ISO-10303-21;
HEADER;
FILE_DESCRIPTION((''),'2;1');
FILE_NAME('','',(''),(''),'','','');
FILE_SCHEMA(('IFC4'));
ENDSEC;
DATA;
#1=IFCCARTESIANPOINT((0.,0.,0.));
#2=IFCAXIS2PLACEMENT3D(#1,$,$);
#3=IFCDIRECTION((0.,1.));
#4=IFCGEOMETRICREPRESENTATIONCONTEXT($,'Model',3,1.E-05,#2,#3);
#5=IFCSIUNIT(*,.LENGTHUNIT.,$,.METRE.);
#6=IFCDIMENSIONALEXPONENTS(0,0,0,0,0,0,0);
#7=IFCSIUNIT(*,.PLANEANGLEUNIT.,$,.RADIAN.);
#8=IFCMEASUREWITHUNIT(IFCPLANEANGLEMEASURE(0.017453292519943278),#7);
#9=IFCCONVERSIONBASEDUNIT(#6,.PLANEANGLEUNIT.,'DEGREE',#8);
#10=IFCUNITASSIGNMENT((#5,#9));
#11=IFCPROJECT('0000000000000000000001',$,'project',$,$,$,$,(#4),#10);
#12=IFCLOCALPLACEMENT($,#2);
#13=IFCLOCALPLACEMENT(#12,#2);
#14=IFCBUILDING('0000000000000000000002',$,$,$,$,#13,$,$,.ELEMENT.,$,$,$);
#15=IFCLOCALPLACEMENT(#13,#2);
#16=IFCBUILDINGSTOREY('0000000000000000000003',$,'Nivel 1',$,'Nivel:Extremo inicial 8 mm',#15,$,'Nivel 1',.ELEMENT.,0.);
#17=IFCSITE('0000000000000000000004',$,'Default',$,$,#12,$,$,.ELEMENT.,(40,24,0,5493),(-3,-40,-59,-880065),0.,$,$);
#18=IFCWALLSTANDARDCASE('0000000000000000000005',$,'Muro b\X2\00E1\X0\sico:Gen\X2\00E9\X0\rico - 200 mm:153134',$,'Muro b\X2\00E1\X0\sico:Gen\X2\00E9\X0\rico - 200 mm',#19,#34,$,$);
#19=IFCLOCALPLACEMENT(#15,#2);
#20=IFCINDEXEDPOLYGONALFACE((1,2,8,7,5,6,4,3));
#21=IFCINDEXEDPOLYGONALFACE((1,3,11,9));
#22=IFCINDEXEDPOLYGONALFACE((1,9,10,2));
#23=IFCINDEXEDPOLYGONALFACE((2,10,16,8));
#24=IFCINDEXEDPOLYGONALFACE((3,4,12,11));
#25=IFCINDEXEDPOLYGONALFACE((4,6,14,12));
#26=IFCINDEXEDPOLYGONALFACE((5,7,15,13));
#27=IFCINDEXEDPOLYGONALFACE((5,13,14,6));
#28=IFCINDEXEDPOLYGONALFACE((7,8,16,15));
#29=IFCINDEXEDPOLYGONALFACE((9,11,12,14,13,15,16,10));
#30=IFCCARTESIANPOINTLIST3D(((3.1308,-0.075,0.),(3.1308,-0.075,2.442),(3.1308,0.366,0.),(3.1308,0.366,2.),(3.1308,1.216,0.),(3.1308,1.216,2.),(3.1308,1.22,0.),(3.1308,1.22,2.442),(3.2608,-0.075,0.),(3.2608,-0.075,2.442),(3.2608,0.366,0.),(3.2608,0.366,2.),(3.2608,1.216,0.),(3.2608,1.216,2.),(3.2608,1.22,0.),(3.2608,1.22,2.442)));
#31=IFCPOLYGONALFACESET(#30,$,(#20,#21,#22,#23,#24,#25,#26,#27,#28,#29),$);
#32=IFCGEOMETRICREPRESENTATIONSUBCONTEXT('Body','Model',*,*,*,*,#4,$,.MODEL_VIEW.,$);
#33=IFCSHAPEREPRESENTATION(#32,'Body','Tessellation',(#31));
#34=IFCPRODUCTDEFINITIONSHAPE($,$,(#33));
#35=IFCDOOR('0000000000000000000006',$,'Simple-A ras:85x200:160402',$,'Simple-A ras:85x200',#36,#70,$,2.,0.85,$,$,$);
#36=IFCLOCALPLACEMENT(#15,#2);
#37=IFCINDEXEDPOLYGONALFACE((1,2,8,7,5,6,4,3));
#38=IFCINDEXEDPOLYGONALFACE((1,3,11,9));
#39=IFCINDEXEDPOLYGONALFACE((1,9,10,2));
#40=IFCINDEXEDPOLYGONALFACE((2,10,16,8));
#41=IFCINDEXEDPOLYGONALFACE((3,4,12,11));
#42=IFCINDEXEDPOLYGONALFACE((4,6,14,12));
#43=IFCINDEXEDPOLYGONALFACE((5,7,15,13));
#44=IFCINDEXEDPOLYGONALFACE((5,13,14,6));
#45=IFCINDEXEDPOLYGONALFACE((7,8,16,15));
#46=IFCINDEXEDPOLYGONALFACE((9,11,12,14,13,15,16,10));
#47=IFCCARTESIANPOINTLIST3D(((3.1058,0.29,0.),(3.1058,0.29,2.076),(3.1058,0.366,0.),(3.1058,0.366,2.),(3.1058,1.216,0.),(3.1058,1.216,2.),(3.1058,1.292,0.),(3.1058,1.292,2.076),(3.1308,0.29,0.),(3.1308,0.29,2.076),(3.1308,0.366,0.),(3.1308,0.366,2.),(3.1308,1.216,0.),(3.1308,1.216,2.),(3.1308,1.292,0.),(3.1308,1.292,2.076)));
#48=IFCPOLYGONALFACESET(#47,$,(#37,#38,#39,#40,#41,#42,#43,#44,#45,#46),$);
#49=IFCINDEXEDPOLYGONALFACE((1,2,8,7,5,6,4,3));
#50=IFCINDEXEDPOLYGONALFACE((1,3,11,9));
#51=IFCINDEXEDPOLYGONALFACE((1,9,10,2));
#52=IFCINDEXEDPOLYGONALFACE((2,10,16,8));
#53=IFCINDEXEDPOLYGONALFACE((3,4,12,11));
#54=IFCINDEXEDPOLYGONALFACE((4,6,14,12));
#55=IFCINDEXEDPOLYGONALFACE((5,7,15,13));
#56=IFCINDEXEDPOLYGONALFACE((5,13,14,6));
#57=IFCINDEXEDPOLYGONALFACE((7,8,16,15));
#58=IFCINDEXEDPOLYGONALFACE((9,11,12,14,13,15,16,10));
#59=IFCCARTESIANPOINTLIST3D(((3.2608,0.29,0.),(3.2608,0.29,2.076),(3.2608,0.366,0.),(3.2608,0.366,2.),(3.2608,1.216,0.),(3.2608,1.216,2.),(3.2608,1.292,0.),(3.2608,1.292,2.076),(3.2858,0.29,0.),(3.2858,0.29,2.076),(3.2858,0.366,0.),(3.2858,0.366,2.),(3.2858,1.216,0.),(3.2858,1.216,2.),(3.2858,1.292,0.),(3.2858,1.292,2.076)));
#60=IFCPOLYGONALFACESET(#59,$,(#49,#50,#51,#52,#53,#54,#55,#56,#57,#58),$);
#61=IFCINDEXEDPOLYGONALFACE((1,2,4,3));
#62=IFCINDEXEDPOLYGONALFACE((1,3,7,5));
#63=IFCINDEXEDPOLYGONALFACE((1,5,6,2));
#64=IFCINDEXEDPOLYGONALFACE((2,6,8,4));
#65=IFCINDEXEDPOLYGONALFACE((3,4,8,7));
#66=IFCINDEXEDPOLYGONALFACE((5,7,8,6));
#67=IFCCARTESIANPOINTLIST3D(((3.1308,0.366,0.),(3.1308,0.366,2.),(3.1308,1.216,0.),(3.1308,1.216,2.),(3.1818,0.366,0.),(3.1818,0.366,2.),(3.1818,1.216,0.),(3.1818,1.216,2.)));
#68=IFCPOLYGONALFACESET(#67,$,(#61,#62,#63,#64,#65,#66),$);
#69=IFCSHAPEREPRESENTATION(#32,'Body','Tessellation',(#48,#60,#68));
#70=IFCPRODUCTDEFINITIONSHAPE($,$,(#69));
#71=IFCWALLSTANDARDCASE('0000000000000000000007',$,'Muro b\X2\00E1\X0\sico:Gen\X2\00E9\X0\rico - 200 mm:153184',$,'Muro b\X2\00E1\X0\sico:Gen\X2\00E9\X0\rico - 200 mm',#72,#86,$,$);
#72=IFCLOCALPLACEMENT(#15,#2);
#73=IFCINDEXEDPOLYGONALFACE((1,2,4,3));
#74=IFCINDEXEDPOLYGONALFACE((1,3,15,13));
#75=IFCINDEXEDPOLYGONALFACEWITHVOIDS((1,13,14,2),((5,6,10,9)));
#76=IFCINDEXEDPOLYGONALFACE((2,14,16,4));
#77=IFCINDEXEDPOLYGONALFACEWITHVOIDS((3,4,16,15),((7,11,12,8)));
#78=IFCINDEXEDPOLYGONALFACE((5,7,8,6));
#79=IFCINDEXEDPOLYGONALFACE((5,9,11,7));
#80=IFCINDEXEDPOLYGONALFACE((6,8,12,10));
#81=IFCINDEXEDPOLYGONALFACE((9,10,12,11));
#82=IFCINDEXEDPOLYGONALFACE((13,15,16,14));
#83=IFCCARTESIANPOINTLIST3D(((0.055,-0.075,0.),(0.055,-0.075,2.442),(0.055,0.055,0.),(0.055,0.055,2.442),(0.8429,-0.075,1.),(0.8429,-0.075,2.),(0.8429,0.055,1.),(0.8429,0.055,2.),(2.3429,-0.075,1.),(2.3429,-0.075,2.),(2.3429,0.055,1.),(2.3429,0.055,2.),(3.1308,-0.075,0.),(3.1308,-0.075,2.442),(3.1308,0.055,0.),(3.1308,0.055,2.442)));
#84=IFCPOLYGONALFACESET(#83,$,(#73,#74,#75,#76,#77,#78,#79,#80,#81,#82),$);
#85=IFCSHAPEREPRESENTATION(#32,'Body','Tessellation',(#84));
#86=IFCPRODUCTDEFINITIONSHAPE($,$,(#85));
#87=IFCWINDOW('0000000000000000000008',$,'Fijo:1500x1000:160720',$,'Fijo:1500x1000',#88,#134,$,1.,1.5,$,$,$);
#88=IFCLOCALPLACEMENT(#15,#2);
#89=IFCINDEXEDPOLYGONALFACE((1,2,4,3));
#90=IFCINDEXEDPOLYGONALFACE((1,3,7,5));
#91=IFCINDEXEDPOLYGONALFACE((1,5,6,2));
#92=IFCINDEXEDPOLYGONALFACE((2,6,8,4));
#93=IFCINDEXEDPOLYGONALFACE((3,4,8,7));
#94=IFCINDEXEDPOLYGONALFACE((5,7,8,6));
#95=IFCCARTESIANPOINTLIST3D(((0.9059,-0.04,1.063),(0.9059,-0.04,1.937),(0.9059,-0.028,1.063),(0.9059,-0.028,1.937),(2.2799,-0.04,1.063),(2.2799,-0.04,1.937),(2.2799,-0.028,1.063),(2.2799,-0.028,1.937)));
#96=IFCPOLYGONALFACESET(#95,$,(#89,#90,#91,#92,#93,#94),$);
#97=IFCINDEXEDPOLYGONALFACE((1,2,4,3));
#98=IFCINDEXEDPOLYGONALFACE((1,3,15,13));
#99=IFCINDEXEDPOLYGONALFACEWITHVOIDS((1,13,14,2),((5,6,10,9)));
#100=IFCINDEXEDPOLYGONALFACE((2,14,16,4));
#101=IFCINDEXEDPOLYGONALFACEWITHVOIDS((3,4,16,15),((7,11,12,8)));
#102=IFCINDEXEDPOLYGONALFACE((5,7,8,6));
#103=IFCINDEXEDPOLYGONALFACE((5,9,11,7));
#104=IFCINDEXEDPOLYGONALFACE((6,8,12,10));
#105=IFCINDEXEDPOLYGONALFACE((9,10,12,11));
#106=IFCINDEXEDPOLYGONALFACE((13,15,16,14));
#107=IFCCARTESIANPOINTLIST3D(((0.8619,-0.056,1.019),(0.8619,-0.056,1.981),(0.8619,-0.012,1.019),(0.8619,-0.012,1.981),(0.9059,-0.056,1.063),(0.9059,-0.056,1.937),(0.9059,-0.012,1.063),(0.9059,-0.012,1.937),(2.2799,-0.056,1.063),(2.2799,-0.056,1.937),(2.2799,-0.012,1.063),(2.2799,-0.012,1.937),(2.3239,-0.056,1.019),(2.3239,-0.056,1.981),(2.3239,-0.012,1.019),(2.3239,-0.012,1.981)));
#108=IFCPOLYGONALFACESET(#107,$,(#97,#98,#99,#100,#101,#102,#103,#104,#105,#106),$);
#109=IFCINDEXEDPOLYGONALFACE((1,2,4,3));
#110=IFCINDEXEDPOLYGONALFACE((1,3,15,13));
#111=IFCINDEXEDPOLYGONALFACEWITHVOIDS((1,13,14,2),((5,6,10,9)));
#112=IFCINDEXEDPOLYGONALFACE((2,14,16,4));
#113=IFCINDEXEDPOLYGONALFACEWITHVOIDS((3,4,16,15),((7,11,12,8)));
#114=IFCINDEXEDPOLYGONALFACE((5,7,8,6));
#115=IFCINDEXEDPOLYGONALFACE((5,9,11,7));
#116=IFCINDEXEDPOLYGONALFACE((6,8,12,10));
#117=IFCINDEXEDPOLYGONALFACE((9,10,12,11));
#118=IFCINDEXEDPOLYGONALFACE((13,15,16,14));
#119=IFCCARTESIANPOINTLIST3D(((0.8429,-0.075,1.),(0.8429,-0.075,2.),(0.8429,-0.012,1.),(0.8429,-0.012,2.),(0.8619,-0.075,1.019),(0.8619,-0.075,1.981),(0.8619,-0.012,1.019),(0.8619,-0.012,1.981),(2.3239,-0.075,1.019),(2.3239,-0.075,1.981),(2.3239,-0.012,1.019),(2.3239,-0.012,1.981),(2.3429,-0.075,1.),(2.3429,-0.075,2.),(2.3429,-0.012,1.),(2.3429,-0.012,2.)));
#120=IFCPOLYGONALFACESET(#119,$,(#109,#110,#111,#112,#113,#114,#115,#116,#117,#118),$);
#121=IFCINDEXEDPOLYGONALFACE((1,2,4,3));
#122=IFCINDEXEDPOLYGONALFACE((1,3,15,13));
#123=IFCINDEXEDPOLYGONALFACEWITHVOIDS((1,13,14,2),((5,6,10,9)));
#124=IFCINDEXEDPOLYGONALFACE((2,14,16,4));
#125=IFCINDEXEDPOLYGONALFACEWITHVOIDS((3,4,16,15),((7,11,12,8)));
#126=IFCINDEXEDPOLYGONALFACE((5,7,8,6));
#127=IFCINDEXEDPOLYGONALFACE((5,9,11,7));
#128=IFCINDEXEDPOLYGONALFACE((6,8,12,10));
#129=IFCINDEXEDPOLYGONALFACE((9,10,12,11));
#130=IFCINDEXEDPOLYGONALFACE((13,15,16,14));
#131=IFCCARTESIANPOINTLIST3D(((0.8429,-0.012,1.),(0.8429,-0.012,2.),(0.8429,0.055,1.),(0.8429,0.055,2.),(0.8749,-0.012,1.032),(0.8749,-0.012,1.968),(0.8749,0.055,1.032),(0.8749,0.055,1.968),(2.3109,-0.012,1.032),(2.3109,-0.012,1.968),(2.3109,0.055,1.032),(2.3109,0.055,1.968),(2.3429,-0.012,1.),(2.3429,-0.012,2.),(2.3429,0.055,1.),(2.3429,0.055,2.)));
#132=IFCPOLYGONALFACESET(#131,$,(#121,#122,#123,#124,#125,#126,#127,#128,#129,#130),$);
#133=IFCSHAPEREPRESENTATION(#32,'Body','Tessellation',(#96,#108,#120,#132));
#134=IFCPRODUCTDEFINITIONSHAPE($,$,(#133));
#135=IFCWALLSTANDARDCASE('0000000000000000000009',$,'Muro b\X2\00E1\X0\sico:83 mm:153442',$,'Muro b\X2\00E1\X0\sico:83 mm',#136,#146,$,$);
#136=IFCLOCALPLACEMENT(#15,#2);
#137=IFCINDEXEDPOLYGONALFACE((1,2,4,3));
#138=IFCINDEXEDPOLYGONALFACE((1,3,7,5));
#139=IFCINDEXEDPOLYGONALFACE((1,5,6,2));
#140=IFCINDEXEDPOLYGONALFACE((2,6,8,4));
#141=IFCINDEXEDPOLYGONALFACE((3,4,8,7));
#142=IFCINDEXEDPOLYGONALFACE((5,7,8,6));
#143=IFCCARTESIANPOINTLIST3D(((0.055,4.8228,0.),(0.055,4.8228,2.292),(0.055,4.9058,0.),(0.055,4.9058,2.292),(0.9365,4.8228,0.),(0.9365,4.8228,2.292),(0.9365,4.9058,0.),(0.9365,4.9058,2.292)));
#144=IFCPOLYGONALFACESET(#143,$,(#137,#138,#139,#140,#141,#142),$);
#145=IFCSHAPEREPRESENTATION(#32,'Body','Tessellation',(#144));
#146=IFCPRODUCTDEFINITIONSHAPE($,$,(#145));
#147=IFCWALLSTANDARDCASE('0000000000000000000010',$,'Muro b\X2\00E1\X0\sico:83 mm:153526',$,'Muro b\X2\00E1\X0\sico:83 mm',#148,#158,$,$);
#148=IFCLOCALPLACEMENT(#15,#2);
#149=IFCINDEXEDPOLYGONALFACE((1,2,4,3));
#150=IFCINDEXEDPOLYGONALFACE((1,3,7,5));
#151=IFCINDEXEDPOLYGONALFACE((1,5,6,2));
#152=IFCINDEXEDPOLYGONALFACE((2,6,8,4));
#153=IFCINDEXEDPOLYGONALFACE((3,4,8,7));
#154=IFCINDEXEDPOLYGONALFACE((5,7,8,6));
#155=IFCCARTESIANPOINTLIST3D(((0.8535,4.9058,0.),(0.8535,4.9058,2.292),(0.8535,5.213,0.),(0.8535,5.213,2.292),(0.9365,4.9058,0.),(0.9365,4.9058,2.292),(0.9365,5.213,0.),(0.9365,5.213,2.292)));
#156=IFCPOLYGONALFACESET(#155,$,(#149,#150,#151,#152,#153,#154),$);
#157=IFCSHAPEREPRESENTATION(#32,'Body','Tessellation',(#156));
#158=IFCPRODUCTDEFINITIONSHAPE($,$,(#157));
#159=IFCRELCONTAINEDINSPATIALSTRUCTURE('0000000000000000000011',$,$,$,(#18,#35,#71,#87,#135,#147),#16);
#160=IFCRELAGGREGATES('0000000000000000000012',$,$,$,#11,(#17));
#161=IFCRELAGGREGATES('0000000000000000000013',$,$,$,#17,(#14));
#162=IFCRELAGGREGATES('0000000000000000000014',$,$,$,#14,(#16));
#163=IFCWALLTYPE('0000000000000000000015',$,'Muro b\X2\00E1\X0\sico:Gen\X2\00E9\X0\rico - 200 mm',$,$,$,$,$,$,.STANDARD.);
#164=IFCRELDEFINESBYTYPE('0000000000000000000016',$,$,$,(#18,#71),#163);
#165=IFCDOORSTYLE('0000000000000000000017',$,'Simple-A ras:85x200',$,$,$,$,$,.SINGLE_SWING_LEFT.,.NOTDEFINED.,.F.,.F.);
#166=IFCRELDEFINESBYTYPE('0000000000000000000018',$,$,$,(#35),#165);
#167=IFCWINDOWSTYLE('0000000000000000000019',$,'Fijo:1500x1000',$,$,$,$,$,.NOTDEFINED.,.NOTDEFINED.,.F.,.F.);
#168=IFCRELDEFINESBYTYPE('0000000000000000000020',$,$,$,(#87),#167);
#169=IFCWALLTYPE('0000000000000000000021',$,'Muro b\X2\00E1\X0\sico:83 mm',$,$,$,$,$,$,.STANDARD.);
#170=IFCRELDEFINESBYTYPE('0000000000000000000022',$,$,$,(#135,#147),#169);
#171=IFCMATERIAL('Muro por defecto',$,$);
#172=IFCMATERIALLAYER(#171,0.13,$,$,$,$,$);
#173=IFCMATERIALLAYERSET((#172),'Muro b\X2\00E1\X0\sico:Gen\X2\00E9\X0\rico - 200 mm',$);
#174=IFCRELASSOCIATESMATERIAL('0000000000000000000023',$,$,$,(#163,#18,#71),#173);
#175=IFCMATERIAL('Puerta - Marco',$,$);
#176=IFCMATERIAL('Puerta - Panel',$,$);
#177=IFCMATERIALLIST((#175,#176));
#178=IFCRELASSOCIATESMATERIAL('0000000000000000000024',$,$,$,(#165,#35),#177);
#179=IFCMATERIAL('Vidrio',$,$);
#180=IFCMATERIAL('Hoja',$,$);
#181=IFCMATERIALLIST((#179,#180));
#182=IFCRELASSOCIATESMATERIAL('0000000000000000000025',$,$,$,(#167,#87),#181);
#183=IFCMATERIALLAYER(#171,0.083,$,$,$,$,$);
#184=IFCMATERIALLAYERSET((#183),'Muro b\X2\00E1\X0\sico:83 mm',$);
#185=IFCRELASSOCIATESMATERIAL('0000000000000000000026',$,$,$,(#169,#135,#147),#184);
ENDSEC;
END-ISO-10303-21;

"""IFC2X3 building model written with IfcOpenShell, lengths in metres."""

from ifc_helpers import new_model, entity, si_unit, converted_unit, direction, frame, frame_2d, origin, origin_2d_with_axis, place, context, subcontext, project, spatial, polyline, rectangle, outline, extrude, clip, bounded_halfspace, source, transform, mapped, material, material_list, layer, layer_set, layer_usage, type_object, type_shapes, element, fill, save


model = new_model("IFC2X3")

# Units and contexts
model_context = context("Model", 3, precision=1e-05, world=origin(), true_north=direction((0.0, 1.0)))
body_context = subcontext(model_context, "Body", "Model", "MODEL_VIEW")
ifc_project = project(units=[si_unit("LENGTHUNIT", "METRE"), converted_unit("PLANEANGLEUNIT", "DEGREE", entity("IfcPlaneAngleMeasure", 0.017453292519943278), si_unit("PLANEANGLEUNIT", "RADIAN"), dimensions=[0, 0, 0, 0, 0, 0, 0])], contexts=[model_context])

# Site, building, storey
site_placement = place(None, origin())
site = spatial("IfcSite", under=ifc_project, at=site_placement, Name="Default", CompositionType="ELEMENT", RefLatitude=(40, 24, 0, 5493), RefLongitude=(-3, -40, -59, -880065), RefElevation=0.0)
building_placement = place(site_placement, origin())
building = spatial("IfcBuilding", under=site, at=building_placement, CompositionType="ELEMENT")
storey_placement = place(building_placement, origin())
storey = spatial("IfcBuildingStorey", under=building, at=storey_placement, Name="Nivel 1", ObjectType="Nivel:Extremo inicial 8 mm", LongName="Nivel 1", CompositionType="ELEMENT", Elevation=0.0)

# Shared definitions
ifc_material_1 = material(Name="Muro por defecto")
ifc_layer_1 = layer(ifc_material_1, 0.13)
ifc_layer_set_1 = layer_set([ifc_layer_1], Name="Muro básico:Genérico - 200 mm")
wall_type_1 = type_object("IfcWallType", Name="Muro básico:Genérico - 200 mm", PredefinedType="STANDARD", material=ifc_layer_set_1)

# Shared definitions
ifc_material_2 = material(Name="Vidrio")
ifc_material_3 = material(Name="Hoja")
ifc_material_list_1 = material_list([ifc_material_2, ifc_material_3])

# Wall, opening, door
ifc_layer_usage_1 = layer_usage(ifc_layer_set_1, "AXIS2", "NEGATIVE", 0.065)
wall_1_placement = place(storey_placement, frame((3.1958, 1.22, 0.0), z_axis=(0.0, 0.0, 1.0), x_axis=(0.0, -1.0, 0.0)))
wall_1 = element("IfcWallStandardCase", 1, at=wall_1_placement, inside=storey, type_object=wall_type_1, material=ifc_layer_usage_1, Name="Muro básico:Genérico - 200 mm:153134", ObjectType="Muro básico:Genérico - 200 mm", context=body_context, shape_type="SweptSolid", body=[
    extrude(rectangle(XDim=1.295, YDim=0.13, at=frame_2d((0.6475, 0.0), x_axis=(1.0, 0.0))), origin(), (0.0, 0.0, 1.0), 2.442),
])
opening_1_placement = place(wall_1_placement, frame((0.854, 0.065, 0.0)))
opening_1 = element("IfcOpeningElement", 2, at=opening_1_placement, cuts=wall_1, ObjectType="Opening", context=body_context, shape_type="SweptSolid", body=[
    extrude(rectangle(XDim=0.85, YDim=2.0, at=frame_2d((1.0, 0.425), x_axis=(0.0, -1.0))), frame((0.0, 0.0, 0.0), z_axis=(0.0, -1.0, 0.0), x_axis=(0.0, 0.0, 1.0)), (0.0, 0.0, 1.0), 0.13),
])
ifc_material_4 = material(Name="Puerta - Marco")
ifc_material_5 = material(Name="Puerta - Panel")
ifc_material_list_2 = material_list([ifc_material_4, ifc_material_5])
door_style_1 = type_object("IfcDoorStyle", Name="Simple-A ras:85x200", ConstructionType="NOTDEFINED", OperationType="SINGLE_SWING_LEFT", ParameterTakesPrecedence=False, Sizeable=False, material=ifc_material_list_2)
shared_shape_1 = source(origin(), body_context, "Body", "SweptSolid", [
    extrude(outline(polyline([(-0.501, -1.057), (0.501, -1.057), (0.501, 1.019), (0.425, 1.019), (0.425, -0.981), (-0.425, -0.981), (-0.425, 1.019), (-0.501, 1.019), (-0.501, -1.057)])), frame((0.425, 0.155, 1.019), z_axis=(0.0, -1.0, 0.0), x_axis=(-1.0, 0.0, 0.0)), (0.0, 0.0, 1.0), 0.025),
    extrude(outline(polyline([(-1.057, -0.501), (1.019, -0.501), (1.019, -0.425), (-0.981, -0.425), (-0.981, 0.425), (1.019, 0.425), (1.019, 0.501), (-1.057, 0.501), (-1.057, -0.501)])), frame((0.425, 0.0, 1.019), z_axis=(0.0, -1.0, 0.0), x_axis=(0.0, 0.0, -1.0)), (0.0, 0.0, 1.0), 0.025),
    extrude(rectangle(XDim=0.85, YDim=0.051, at=frame_2d((0.0, 0.0), x_axis=(1.0, 0.0))), frame((0.425, 0.1045, 0.0)), (0.0, 0.0, 1.0), 2.0),
])
type_shapes(door_style_1, [shared_shape_1])
door_1_placement = place(opening_1_placement, frame((0.0, 0.0, 0.0), z_axis=(0.0, 0.0, 1.0), x_axis=(-1.0, 0.0, 0.0)))
door_1 = element("IfcDoor", 3, at=door_1_placement, inside=storey, type_object=door_style_1, material=ifc_material_list_2, Name="Simple-A ras:85x200:160402", ObjectType="Simple-A ras:85x200", OverallHeight=2.0, OverallWidth=0.85, context=body_context, shape_type="MappedRepresentation", body=[
    mapped(shared_shape_1, transform((0.0, 0.0, 0.0), scale=1.0)),
])
fill(opening_1, door_1)

# Wall, opening, window
ifc_layer_usage_2 = layer_usage(ifc_layer_set_1, "AXIS2", "NEGATIVE", 0.065)
wall_2_placement = place(storey_placement, frame((3.1308, -0.01, 0.0), z_axis=(0.0, 0.0, 1.0), x_axis=(-1.0, 0.0, 0.0)))
wall_2 = element("IfcWallStandardCase", 4, at=wall_2_placement, inside=storey, type_object=wall_type_1, material=ifc_layer_usage_2, Name="Muro básico:Genérico - 200 mm:153184", ObjectType="Muro básico:Genérico - 200 mm", context=body_context, shape_type="SweptSolid", body=[
    extrude(rectangle(XDim=3.0758, YDim=0.13, at=frame_2d((1.5379, 0.0), x_axis=(-1.0, 0.0))), origin(), (0.0, 0.0, 1.0), 2.442),
])
opening_2_placement = place(wall_2_placement, frame((0.7879, -0.065, 1.0)))
opening_2 = element("IfcOpeningElement", 5, at=opening_2_placement, cuts=wall_2, ObjectType="Opening", context=body_context, shape_type="SweptSolid", body=[
    extrude(rectangle(XDim=1.0, YDim=1.5, at=frame_2d((0.5, 0.75), x_axis=(1.0, 0.0))), frame((0.0, 0.0, 0.0), z_axis=(0.0, 1.0, 0.0), x_axis=(0.0, 0.0, 1.0)), (0.0, 0.0, 1.0), 0.13),
])
window_style_1 = type_object("IfcWindowStyle", Name="Fijo:1500x1000", ConstructionType="NOTDEFINED", OperationType="NOTDEFINED", ParameterTakesPrecedence=False, Sizeable=False, material=ifc_material_list_1)
shared_shape_2 = source(origin(), body_context, "Body", "SweptSolid", [
    extrude(rectangle(XDim=0.012, YDim=1.374, at=origin_2d_with_axis()), frame((0.75, 0.089, 0.063), z_axis=(0.0, 0.0, 1.0), x_axis=(0.0, -1.0, 0.0)), (0.0, 0.0, 1.0), 0.874),
    extrude(outline(polyline([(-0.731, -0.481), (0.731, -0.481), (0.731, 0.481), (-0.731, 0.481), (-0.731, -0.481)]), holes=[polyline([(-0.687, -0.437), (-0.687, 0.437), (0.687, 0.437), (0.687, -0.437), (-0.687, -0.437)])]), frame((0.75, 0.067, 0.5), z_axis=(0.0, 1.0, 0.0), x_axis=(1.0, 0.0, 0.0)), (0.0, 0.0, 1.0), 0.044),
    extrude(outline(polyline([(-0.75, -0.5), (0.75, -0.5), (0.75, 0.5), (-0.75, 0.5), (-0.75, -0.5)]), holes=[polyline([(-0.731, -0.481), (-0.731, 0.481), (0.731, 0.481), (0.731, -0.481), (-0.731, -0.481)])]), frame((0.75, 0.067, 0.5), z_axis=(0.0, 1.0, 0.0), x_axis=(1.0, 0.0, 0.0)), (0.0, 0.0, 1.0), 0.063),
    extrude(outline(polyline([(-0.75, -0.5), (0.75, -0.5), (0.75, 0.5), (-0.75, 0.5), (-0.75, -0.5)]), holes=[polyline([(-0.718, -0.468), (-0.718, 0.468), (0.718, 0.468), (0.718, -0.468), (-0.718, -0.468)])]), frame((0.75, 0.0, 0.5), z_axis=(0.0, 1.0, 0.0), x_axis=(1.0, 0.0, 0.0)), (0.0, 0.0, 1.0), 0.067),
])
type_shapes(window_style_1, [shared_shape_2])
window_1_placement = place(opening_2_placement, origin())
window_1 = element("IfcWindow", 6, at=window_1_placement, inside=storey, type_object=window_style_1, material=ifc_material_list_1, Name="Fijo:1500x1000:160720", ObjectType="Fijo:1500x1000", OverallHeight=1.0, OverallWidth=1.5, context=body_context, shape_type="MappedRepresentation", body=[
    mapped(shared_shape_2, transform((0.0, 0.0, 0.0), scale=1.0)),
])
fill(opening_2, window_1)

# Walls
ifc_layer_2 = layer(ifc_material_1, 0.083)
ifc_layer_set_2 = layer_set([ifc_layer_2], Name="Muro básico:83 mm")
ifc_layer_usage_3 = layer_usage(ifc_layer_set_2, "AXIS2", "NEGATIVE", 0.0415)
wall_type_2 = type_object("IfcWallType", Name="Muro básico:83 mm", PredefinedType="STANDARD", material=ifc_layer_set_2)
wall_3_placement = place(storey_placement, frame((0.055, 4.8643, 0.0)))
element("IfcWallStandardCase", 7, at=wall_3_placement, inside=storey, type_object=wall_type_2, material=ifc_layer_usage_3, Name="Muro básico:83 mm:153442", ObjectType="Muro básico:83 mm", context=body_context, shape_type="Clipping", body=[
    clip(extrude(rectangle(XDim=0.8815, YDim=0.083, at=frame_2d((0.4408, 0.0), x_axis=(-1.0, 0.0))), origin(), (0.0, 0.0, 1.0), 2.292), bounded_halfspace(frame((0.0, -0.0415, 2.292), z_axis=(0.0, 0.0, -1.0), x_axis=(1.0, 0.0, 0.0)), True, frame((0.0, -0.0415, 2.292)), polyline([(0.0, 0.0), (0.8815, 0.0), (0.8815, 0.083), (0.7985, 0.083), (0.0, 0.083), (0.0, 0.0)]))),
])
ifc_layer_usage_4 = layer_usage(ifc_layer_set_2, "AXIS2", "NEGATIVE", 0.0415)
wall_4_placement = place(storey_placement, frame((0.895, 4.9058, 0.0), z_axis=(0.0, 0.0, 1.0), x_axis=(0.0, 1.0, 0.0)))
element("IfcWallStandardCase", 8, at=wall_4_placement, inside=storey, type_object=wall_type_2, material=ifc_layer_usage_4, Name="Muro básico:83 mm:153526", ObjectType="Muro básico:83 mm", context=body_context, shape_type="Clipping", body=[
    clip(extrude(rectangle(XDim=0.3072, YDim=0.083, at=frame_2d((0.1536, 0.0), x_axis=(-1.0, 0.0))), origin(), (0.0, 0.0, 1.0), 2.292), bounded_halfspace(frame((0.0, -0.0415, 2.292), z_axis=(0.0, 0.0, -1.0), x_axis=(0.0, -1.0, 0.0)), True, frame((0.0, -0.0415, 2.292)), polyline([(0.0, 0.0), (0.2242, 0.0), (0.3072, 0.0), (0.3072, 0.083), (0.0, 0.083), (0.0, 0.0)]))),
])

save(model, "model.ifc")
